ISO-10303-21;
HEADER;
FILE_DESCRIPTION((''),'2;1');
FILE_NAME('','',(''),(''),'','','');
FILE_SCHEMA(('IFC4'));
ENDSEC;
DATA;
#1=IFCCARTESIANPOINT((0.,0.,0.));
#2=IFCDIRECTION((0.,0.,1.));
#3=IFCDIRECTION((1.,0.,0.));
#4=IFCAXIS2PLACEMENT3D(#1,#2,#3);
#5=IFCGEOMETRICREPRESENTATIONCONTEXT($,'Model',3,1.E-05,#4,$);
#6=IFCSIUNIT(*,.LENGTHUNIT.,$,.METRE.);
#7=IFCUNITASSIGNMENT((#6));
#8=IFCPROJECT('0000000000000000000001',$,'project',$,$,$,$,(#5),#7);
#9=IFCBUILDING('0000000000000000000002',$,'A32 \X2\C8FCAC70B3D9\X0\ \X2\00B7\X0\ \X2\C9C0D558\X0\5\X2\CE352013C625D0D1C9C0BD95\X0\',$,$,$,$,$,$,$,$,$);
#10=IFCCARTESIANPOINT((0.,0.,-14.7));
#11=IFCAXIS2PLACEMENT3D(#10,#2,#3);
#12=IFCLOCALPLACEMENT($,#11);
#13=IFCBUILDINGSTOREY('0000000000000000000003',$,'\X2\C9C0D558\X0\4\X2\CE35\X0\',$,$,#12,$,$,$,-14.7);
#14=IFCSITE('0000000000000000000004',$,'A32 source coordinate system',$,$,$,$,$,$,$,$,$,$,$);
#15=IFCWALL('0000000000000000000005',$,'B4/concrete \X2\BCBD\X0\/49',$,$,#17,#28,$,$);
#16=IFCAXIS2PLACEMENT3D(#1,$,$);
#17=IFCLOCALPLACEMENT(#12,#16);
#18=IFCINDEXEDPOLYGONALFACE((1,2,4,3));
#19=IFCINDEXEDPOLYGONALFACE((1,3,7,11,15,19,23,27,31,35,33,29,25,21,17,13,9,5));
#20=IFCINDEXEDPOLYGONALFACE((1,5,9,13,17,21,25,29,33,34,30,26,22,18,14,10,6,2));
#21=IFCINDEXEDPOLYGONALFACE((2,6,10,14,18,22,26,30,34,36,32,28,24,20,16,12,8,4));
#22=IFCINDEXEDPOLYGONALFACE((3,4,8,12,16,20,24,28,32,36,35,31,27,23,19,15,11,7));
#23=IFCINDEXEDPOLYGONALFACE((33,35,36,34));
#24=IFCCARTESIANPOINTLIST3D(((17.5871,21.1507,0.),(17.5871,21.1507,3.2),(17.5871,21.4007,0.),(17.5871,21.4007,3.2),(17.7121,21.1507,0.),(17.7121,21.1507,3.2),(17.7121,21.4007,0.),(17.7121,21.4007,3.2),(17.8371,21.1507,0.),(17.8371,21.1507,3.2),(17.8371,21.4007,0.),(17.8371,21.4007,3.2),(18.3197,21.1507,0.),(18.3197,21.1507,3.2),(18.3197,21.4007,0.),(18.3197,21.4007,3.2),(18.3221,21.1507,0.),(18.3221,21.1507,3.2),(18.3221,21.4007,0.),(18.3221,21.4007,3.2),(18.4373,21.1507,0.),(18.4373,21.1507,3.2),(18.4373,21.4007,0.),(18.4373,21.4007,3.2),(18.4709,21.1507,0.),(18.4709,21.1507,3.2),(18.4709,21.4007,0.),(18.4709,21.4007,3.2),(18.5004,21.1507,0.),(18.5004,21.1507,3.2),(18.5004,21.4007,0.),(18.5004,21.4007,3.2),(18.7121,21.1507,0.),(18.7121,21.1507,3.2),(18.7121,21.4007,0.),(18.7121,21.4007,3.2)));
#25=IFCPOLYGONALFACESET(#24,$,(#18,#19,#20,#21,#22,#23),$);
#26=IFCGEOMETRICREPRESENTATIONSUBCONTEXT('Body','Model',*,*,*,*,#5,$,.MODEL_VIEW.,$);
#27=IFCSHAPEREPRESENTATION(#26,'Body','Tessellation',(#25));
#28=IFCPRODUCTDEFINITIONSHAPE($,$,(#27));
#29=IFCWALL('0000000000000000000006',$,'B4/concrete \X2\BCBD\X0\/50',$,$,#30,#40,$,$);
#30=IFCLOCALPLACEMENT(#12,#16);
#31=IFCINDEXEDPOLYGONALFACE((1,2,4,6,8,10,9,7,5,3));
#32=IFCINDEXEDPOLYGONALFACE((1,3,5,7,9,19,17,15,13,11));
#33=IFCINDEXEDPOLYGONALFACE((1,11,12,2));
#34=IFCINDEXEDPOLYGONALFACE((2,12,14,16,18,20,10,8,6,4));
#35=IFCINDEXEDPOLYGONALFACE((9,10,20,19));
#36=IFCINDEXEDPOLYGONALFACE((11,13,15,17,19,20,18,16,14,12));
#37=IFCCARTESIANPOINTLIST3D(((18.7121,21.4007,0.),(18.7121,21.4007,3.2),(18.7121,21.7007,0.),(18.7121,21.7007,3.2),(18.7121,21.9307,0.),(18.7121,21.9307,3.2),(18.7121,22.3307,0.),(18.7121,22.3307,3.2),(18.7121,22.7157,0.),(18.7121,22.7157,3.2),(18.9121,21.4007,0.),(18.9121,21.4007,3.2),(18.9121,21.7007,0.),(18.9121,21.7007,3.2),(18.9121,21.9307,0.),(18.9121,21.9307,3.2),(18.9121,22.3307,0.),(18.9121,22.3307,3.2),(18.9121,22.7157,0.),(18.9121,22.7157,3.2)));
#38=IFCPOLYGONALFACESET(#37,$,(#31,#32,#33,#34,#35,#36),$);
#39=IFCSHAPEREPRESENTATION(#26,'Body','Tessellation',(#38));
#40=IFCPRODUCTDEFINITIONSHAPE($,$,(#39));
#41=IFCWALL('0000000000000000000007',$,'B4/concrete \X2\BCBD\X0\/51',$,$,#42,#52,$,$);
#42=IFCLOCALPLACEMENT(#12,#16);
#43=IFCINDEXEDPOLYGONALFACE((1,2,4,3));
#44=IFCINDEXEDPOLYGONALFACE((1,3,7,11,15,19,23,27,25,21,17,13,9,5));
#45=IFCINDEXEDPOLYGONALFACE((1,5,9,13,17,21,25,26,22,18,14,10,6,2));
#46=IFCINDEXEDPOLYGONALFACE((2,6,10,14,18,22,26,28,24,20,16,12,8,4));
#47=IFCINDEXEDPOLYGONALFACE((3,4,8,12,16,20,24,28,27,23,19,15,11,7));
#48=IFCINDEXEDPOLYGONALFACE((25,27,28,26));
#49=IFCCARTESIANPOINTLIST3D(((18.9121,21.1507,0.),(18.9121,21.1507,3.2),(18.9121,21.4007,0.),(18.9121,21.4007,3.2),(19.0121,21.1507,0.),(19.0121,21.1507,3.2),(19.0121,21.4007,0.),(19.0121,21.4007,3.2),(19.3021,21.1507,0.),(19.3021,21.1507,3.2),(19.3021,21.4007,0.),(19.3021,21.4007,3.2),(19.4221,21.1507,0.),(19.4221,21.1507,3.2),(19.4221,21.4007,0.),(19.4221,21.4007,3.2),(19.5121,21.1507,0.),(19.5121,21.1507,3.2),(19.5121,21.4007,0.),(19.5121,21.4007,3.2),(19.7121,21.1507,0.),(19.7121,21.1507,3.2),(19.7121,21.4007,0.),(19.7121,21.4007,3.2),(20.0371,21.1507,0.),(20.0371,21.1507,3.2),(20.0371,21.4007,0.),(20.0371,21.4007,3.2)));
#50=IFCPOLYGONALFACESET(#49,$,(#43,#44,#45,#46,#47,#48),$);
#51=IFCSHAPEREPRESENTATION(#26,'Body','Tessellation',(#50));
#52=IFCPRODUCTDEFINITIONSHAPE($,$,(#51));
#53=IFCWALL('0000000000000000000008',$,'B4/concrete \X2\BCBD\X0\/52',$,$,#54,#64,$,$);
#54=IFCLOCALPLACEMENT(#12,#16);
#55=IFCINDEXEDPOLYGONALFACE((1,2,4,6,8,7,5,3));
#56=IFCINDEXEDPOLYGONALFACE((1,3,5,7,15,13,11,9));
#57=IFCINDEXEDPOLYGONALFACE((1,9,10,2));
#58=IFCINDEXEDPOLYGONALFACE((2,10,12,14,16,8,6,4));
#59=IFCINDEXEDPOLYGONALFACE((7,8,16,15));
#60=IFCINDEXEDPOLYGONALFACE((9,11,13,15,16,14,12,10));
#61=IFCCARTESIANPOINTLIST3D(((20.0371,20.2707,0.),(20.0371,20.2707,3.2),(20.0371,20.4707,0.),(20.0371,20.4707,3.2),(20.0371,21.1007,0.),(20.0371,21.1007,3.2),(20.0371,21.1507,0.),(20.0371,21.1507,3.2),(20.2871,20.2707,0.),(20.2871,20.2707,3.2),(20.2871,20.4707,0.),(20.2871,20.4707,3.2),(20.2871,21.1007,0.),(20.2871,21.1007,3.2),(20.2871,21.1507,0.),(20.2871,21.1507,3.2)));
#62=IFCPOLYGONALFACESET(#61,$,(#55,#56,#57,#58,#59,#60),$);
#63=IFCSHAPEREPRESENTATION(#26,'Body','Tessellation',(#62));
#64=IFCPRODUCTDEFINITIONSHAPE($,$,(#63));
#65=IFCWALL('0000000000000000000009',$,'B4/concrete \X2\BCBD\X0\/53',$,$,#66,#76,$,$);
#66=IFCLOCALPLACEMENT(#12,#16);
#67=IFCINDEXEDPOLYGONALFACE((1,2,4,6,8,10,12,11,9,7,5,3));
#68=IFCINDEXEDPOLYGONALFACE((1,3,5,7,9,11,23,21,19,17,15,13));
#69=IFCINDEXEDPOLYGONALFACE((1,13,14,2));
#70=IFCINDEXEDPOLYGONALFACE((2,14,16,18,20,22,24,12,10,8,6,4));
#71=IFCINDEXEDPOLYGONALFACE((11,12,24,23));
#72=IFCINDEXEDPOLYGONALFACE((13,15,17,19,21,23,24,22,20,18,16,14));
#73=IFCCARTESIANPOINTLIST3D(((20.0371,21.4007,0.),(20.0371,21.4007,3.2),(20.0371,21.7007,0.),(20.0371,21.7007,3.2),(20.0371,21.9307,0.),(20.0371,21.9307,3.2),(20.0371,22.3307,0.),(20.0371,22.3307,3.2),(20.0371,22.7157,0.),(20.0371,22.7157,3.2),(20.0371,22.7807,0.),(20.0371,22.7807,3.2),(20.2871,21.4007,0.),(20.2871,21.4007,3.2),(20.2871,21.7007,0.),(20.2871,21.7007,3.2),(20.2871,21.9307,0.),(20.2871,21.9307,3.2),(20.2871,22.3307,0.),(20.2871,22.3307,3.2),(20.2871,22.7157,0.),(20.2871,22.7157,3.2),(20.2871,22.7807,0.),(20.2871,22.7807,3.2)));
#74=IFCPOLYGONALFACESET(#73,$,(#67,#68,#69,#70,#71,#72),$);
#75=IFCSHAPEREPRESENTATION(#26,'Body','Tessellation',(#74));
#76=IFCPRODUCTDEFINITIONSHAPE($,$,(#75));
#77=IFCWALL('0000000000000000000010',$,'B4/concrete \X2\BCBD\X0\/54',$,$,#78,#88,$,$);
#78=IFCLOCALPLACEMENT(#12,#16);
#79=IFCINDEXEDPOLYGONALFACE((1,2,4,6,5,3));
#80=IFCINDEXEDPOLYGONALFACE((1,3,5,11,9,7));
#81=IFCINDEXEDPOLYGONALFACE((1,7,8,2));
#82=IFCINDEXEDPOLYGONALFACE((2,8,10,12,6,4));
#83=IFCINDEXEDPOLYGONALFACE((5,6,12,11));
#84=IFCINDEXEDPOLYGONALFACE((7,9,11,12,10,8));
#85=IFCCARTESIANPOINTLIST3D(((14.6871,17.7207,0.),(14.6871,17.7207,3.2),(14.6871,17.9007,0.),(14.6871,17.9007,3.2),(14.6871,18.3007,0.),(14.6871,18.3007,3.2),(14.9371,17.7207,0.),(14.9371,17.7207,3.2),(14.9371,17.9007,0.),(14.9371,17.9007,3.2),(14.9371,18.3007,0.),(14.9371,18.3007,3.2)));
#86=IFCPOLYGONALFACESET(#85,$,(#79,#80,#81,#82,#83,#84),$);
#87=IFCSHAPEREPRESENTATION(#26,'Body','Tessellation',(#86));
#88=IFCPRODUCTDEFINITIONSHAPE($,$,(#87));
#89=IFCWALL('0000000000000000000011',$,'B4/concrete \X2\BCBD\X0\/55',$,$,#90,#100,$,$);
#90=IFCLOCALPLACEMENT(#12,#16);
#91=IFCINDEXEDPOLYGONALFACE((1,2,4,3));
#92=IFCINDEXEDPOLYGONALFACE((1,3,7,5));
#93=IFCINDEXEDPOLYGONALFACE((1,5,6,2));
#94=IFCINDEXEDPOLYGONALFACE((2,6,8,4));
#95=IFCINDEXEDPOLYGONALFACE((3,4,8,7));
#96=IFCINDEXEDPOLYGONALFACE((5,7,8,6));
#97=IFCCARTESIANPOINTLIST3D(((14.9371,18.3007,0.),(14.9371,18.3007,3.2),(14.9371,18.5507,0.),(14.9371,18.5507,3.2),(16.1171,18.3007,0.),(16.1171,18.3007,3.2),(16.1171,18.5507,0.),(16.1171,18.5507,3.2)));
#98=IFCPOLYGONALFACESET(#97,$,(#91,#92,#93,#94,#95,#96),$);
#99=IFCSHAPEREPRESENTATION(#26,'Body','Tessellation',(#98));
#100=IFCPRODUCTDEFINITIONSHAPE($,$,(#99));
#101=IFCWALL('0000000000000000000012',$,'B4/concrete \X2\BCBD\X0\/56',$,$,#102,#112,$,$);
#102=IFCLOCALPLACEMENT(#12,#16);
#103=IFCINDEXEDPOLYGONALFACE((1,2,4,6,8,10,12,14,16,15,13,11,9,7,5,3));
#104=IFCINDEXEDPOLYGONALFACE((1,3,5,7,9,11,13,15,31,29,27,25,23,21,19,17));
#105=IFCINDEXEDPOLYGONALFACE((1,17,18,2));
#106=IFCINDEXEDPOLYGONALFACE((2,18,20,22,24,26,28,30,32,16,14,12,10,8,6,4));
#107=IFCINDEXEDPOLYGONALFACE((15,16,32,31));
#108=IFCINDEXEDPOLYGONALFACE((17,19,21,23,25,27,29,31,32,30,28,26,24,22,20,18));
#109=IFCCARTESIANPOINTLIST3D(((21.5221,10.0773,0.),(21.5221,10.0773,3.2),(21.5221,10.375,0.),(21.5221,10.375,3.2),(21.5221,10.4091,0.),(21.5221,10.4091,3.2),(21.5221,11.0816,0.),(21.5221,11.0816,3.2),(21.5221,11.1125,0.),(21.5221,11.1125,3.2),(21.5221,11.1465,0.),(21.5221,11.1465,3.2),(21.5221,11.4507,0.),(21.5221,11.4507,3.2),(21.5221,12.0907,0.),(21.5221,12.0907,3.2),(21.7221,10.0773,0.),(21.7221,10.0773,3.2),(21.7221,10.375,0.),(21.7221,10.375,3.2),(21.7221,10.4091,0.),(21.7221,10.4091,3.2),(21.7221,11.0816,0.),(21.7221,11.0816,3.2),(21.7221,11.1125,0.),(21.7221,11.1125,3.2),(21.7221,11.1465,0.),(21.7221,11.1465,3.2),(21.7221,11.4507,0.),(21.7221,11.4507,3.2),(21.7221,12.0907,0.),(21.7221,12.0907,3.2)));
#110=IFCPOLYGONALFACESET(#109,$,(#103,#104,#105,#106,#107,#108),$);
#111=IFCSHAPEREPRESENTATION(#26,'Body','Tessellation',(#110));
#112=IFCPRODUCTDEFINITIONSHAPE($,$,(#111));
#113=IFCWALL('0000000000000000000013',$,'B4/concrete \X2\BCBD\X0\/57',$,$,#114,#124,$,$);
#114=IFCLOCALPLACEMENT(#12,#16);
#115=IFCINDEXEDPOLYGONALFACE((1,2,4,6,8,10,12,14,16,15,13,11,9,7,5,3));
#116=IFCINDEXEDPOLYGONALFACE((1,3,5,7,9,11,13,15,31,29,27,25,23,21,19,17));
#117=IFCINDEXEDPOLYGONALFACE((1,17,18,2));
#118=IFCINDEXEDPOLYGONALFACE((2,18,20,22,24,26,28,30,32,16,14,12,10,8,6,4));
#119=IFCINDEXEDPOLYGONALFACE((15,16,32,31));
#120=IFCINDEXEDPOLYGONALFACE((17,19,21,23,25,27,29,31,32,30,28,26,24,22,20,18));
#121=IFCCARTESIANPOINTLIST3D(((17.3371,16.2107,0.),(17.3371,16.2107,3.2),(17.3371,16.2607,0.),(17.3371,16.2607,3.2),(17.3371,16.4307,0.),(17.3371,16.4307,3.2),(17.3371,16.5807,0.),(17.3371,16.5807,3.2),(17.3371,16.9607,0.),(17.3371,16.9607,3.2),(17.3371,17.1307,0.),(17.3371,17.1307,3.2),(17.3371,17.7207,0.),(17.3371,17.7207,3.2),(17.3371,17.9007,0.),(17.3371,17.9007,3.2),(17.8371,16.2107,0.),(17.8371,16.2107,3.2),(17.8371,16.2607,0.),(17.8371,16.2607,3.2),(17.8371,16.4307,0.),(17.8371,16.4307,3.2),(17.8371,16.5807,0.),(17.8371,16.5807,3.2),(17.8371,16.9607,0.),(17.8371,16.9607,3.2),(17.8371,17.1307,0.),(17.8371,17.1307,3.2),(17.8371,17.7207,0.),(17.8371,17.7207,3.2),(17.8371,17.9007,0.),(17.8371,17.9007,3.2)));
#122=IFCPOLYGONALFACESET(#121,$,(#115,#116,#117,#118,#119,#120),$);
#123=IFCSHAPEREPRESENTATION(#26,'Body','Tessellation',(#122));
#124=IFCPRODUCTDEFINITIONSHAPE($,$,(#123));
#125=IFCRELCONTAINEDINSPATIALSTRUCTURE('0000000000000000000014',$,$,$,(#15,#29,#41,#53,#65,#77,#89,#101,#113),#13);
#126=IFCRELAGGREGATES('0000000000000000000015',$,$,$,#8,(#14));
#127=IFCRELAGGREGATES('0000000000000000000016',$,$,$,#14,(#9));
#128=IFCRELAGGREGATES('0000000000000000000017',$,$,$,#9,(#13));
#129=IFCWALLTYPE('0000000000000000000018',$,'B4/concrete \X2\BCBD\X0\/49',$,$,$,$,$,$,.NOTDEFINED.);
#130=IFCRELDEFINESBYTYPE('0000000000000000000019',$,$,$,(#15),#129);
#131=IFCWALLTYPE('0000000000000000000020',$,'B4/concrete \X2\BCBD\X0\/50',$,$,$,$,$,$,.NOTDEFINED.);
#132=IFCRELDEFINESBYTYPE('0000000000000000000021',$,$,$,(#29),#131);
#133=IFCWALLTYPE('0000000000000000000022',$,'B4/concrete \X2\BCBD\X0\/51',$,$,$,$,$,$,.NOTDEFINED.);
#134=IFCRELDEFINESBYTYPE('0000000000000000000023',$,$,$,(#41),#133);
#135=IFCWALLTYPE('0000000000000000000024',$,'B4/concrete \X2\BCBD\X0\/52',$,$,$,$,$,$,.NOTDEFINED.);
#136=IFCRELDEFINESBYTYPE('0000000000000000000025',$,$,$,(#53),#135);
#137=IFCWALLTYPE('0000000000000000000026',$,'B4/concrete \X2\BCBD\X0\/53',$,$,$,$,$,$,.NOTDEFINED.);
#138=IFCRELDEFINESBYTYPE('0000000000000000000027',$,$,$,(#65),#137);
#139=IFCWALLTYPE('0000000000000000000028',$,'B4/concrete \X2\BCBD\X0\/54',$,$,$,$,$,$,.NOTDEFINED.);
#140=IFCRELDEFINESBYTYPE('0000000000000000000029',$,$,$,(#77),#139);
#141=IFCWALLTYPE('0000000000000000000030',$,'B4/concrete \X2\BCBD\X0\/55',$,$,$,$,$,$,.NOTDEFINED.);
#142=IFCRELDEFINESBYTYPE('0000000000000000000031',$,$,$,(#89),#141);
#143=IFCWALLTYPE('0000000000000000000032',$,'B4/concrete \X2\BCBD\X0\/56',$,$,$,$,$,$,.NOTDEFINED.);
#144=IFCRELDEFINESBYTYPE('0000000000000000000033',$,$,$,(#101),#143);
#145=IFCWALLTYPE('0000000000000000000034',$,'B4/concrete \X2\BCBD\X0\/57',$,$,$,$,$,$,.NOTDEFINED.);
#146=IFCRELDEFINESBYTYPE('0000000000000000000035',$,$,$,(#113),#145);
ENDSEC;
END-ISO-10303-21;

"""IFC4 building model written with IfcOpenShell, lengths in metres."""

from ifc_helpers import new_model, si_unit, frame, origin, origin_with_axes, place, context, subcontext, project, spatial, polyline, outline, extrude, source, transform, mapped, type_object, type_shapes, element, save


model = new_model("IFC4")

# Units and contexts
model_context = context("Model", 3, precision=1e-05, world=origin_with_axes())
body_context = subcontext(model_context, "Body", "Model", "MODEL_VIEW")
ifc_project = project(units=[si_unit("LENGTHUNIT", "METRE")], contexts=[model_context])

# Site, building, storey
site = spatial("IfcSite", under=ifc_project, Name="A32 source coordinate system")
building = spatial("IfcBuilding", under=site, Name="A32 주거동 · 지하5층–옥탑지붕")
storey_placement = place(None, frame((0.0, 0.0, -14.7), z_axis=(0.0, 0.0, 1.0), x_axis=(1.0, 0.0, 0.0)))
storey = spatial("IfcBuildingStorey", under=building, at=storey_placement, Name="지하4층", Elevation=-14.7)

# Walls
wall_type_1 = type_object("IfcWallType", Name="B4/concrete 벽/49", PredefinedType="NOTDEFINED")
shared_shape_1 = source(origin(), body_context, "Body", "SweptSolid", [
    extrude(outline(polyline([(17.8371, 21.4007), (18.3197, 21.4007), (18.3221, 21.4007), (18.4373, 21.4007), (18.4709, 21.4007), (18.5004, 21.4007), (18.7121, 21.4007), (18.7121, 21.1507), (18.5004, 21.1507), (18.4709, 21.1507), (18.4373, 21.1507), (18.3221, 21.1507), (18.3197, 21.1507), (17.8371, 21.1507), (17.7121, 21.1507), (17.5871, 21.1507), (17.5871, 21.4007), (17.7121, 21.4007), (17.8371, 21.4007)])), origin(), (0.0, 0.0, 1.0), 3.2),
])
type_shapes(wall_type_1, [shared_shape_1])
wall_1_placement = place(storey_placement, origin_with_axes())
element("IfcWall", 1, at=wall_1_placement, inside=storey, type_object=wall_type_1, Name="B4/concrete 벽/49", context=body_context, shape_type="MappedRepresentation", body=[
    mapped(shared_shape_1, transform((0.0, 0.0, 0.0), scale=1.0)),
])
wall_type_2 = type_object("IfcWallType", Name="B4/concrete 벽/50", PredefinedType="NOTDEFINED")
shared_shape_2 = source(origin(), body_context, "Body", "SweptSolid", [
    extrude(outline(polyline([(18.7121, 22.3307), (18.7121, 22.7157), (18.9121, 22.7157), (18.9121, 22.3307), (18.9121, 21.9307), (18.9121, 21.7007), (18.9121, 21.4007), (18.7121, 21.4007), (18.7121, 21.7007), (18.7121, 21.9307), (18.7121, 22.3307)])), origin(), (0.0, 0.0, 1.0), 3.2),
])
type_shapes(wall_type_2, [shared_shape_2])
wall_2_placement = place(storey_placement, origin_with_axes())
element("IfcWall", 2, at=wall_2_placement, inside=storey, type_object=wall_type_2, Name="B4/concrete 벽/50", context=body_context, shape_type="MappedRepresentation", body=[
    mapped(shared_shape_2, transform((0.0, 0.0, 0.0), scale=1.0)),
])
wall_type_3 = type_object("IfcWallType", Name="B4/concrete 벽/51", PredefinedType="NOTDEFINED")
shared_shape_3 = source(origin(), body_context, "Body", "SweptSolid", [
    extrude(outline(polyline([(19.4221, 21.4007), (19.5121, 21.4007), (19.7121, 21.4007), (20.0371, 21.4007), (20.0371, 21.1507), (19.7121, 21.1507), (19.5121, 21.1507), (19.4221, 21.1507), (19.3021, 21.1507), (19.0121, 21.1507), (18.9121, 21.1507), (18.9121, 21.4007), (19.0121, 21.4007), (19.3021, 21.4007), (19.4221, 21.4007)])), origin(), (0.0, 0.0, 1.0), 3.2),
])
type_shapes(wall_type_3, [shared_shape_3])
wall_3_placement = place(storey_placement, origin_with_axes())
element("IfcWall", 3, at=wall_3_placement, inside=storey, type_object=wall_type_3, Name="B4/concrete 벽/51", context=body_context, shape_type="MappedRepresentation", body=[
    mapped(shared_shape_3, transform((0.0, 0.0, 0.0), scale=1.0)),
])
wall_type_4 = type_object("IfcWallType", Name="B4/concrete 벽/52", PredefinedType="NOTDEFINED")
shared_shape_4 = source(origin(), body_context, "Body", "SweptSolid", [
    extrude(outline(polyline([(20.2871, 20.4707), (20.2871, 20.2707), (20.0371, 20.2707), (20.0371, 20.4707), (20.0371, 21.1007), (20.0371, 21.1507), (20.2871, 21.1507), (20.2871, 21.1007), (20.2871, 20.4707)])), origin(), (0.0, 0.0, 1.0), 3.2),
])
type_shapes(wall_type_4, [shared_shape_4])
wall_4_placement = place(storey_placement, origin_with_axes())
element("IfcWall", 4, at=wall_4_placement, inside=storey, type_object=wall_type_4, Name="B4/concrete 벽/52", context=body_context, shape_type="MappedRepresentation", body=[
    mapped(shared_shape_4, transform((0.0, 0.0, 0.0), scale=1.0)),
])
wall_type_5 = type_object("IfcWallType", Name="B4/concrete 벽/53", PredefinedType="NOTDEFINED")
shared_shape_5 = source(origin(), body_context, "Body", "SweptSolid", [
    extrude(outline(polyline([(20.0371, 22.3307), (20.0371, 22.7157), (20.0371, 22.7807), (20.2871, 22.7807), (20.2871, 22.7157), (20.2871, 22.3307), (20.2871, 21.9307), (20.2871, 21.7007), (20.2871, 21.4007), (20.0371, 21.4007), (20.0371, 21.7007), (20.0371, 21.9307), (20.0371, 22.3307)])), origin(), (0.0, 0.0, 1.0), 3.2),
])
type_shapes(wall_type_5, [shared_shape_5])
wall_5_placement = place(storey_placement, origin_with_axes())
element("IfcWall", 5, at=wall_5_placement, inside=storey, type_object=wall_type_5, Name="B4/concrete 벽/53", context=body_context, shape_type="MappedRepresentation", body=[
    mapped(shared_shape_5, transform((0.0, 0.0, 0.0), scale=1.0)),
])
wall_type_6 = type_object("IfcWallType", Name="B4/concrete 벽/54", PredefinedType="NOTDEFINED")
shared_shape_6 = source(origin(), body_context, "Body", "SweptSolid", [
    extrude(outline(polyline([(14.9371, 17.7207), (14.6871, 17.7207), (14.6871, 17.9007), (14.6871, 18.3007), (14.9371, 18.3007), (14.9371, 17.9007), (14.9371, 17.7207)])), origin(), (0.0, 0.0, 1.0), 3.2),
])
type_shapes(wall_type_6, [shared_shape_6])
wall_6_placement = place(storey_placement, origin_with_axes())
element("IfcWall", 6, at=wall_6_placement, inside=storey, type_object=wall_type_6, Name="B4/concrete 벽/54", context=body_context, shape_type="MappedRepresentation", body=[
    mapped(shared_shape_6, transform((0.0, 0.0, 0.0), scale=1.0)),
])
wall_type_7 = type_object("IfcWallType", Name="B4/concrete 벽/55", PredefinedType="NOTDEFINED")
shared_shape_7 = source(origin(), body_context, "Body", "SweptSolid", [
    extrude(outline(polyline([(16.1171, 18.3007), (14.9371, 18.3007), (14.9371, 18.5507), (16.1171, 18.5507), (16.1171, 18.3007)])), origin(), (0.0, 0.0, 1.0), 3.2),
])
type_shapes(wall_type_7, [shared_shape_7])
wall_7_placement = place(storey_placement, origin_with_axes())
element("IfcWall", 7, at=wall_7_placement, inside=storey, type_object=wall_type_7, Name="B4/concrete 벽/55", context=body_context, shape_type="MappedRepresentation", body=[
    mapped(shared_shape_7, transform((0.0, 0.0, 0.0), scale=1.0)),
])
wall_type_8 = type_object("IfcWallType", Name="B4/concrete 벽/56", PredefinedType="NOTDEFINED")
shared_shape_8 = source(origin(), body_context, "Body", "SweptSolid", [
    extrude(outline(polyline([(21.7221, 11.1125), (21.7221, 11.0816), (21.7221, 10.4091), (21.7221, 10.375), (21.7221, 10.0773), (21.5221, 10.0773), (21.5221, 10.375), (21.5221, 10.4091), (21.5221, 11.0816), (21.5221, 11.1125), (21.5221, 11.1465), (21.5221, 11.4507), (21.5221, 12.0907), (21.7221, 12.0907), (21.7221, 11.4507), (21.7221, 11.1465), (21.7221, 11.1125)])), origin(), (0.0, 0.0, 1.0), 3.2),
])
type_shapes(wall_type_8, [shared_shape_8])
wall_8_placement = place(storey_placement, origin_with_axes())
element("IfcWall", 8, at=wall_8_placement, inside=storey, type_object=wall_type_8, Name="B4/concrete 벽/56", context=body_context, shape_type="MappedRepresentation", body=[
    mapped(shared_shape_8, transform((0.0, 0.0, 0.0), scale=1.0)),
])
wall_type_9 = type_object("IfcWallType", Name="B4/concrete 벽/57", PredefinedType="NOTDEFINED")
shared_shape_9 = source(origin(), body_context, "Body", "SweptSolid", [
    extrude(outline(polyline([(17.8371, 17.1307), (17.8371, 16.9607), (17.8371, 16.5807), (17.8371, 16.4307), (17.8371, 16.2607), (17.8371, 16.2107), (17.3371, 16.2107), (17.3371, 16.2607), (17.3371, 16.4307), (17.3371, 16.5807), (17.3371, 16.9607), (17.3371, 17.1307), (17.3371, 17.7207), (17.3371, 17.9007), (17.8371, 17.9007), (17.8371, 17.7207), (17.8371, 17.1307)])), origin(), (0.0, 0.0, 1.0), 3.2),
])
type_shapes(wall_type_9, [shared_shape_9])
wall_9_placement = place(storey_placement, origin_with_axes())
element("IfcWall", 9, at=wall_9_placement, inside=storey, type_object=wall_type_9, Name="B4/concrete 벽/57", context=body_context, shape_type="MappedRepresentation", body=[
    mapped(shared_shape_9, transform((0.0, 0.0, 0.0), scale=1.0)),
])

save(model, "model.ifc")
